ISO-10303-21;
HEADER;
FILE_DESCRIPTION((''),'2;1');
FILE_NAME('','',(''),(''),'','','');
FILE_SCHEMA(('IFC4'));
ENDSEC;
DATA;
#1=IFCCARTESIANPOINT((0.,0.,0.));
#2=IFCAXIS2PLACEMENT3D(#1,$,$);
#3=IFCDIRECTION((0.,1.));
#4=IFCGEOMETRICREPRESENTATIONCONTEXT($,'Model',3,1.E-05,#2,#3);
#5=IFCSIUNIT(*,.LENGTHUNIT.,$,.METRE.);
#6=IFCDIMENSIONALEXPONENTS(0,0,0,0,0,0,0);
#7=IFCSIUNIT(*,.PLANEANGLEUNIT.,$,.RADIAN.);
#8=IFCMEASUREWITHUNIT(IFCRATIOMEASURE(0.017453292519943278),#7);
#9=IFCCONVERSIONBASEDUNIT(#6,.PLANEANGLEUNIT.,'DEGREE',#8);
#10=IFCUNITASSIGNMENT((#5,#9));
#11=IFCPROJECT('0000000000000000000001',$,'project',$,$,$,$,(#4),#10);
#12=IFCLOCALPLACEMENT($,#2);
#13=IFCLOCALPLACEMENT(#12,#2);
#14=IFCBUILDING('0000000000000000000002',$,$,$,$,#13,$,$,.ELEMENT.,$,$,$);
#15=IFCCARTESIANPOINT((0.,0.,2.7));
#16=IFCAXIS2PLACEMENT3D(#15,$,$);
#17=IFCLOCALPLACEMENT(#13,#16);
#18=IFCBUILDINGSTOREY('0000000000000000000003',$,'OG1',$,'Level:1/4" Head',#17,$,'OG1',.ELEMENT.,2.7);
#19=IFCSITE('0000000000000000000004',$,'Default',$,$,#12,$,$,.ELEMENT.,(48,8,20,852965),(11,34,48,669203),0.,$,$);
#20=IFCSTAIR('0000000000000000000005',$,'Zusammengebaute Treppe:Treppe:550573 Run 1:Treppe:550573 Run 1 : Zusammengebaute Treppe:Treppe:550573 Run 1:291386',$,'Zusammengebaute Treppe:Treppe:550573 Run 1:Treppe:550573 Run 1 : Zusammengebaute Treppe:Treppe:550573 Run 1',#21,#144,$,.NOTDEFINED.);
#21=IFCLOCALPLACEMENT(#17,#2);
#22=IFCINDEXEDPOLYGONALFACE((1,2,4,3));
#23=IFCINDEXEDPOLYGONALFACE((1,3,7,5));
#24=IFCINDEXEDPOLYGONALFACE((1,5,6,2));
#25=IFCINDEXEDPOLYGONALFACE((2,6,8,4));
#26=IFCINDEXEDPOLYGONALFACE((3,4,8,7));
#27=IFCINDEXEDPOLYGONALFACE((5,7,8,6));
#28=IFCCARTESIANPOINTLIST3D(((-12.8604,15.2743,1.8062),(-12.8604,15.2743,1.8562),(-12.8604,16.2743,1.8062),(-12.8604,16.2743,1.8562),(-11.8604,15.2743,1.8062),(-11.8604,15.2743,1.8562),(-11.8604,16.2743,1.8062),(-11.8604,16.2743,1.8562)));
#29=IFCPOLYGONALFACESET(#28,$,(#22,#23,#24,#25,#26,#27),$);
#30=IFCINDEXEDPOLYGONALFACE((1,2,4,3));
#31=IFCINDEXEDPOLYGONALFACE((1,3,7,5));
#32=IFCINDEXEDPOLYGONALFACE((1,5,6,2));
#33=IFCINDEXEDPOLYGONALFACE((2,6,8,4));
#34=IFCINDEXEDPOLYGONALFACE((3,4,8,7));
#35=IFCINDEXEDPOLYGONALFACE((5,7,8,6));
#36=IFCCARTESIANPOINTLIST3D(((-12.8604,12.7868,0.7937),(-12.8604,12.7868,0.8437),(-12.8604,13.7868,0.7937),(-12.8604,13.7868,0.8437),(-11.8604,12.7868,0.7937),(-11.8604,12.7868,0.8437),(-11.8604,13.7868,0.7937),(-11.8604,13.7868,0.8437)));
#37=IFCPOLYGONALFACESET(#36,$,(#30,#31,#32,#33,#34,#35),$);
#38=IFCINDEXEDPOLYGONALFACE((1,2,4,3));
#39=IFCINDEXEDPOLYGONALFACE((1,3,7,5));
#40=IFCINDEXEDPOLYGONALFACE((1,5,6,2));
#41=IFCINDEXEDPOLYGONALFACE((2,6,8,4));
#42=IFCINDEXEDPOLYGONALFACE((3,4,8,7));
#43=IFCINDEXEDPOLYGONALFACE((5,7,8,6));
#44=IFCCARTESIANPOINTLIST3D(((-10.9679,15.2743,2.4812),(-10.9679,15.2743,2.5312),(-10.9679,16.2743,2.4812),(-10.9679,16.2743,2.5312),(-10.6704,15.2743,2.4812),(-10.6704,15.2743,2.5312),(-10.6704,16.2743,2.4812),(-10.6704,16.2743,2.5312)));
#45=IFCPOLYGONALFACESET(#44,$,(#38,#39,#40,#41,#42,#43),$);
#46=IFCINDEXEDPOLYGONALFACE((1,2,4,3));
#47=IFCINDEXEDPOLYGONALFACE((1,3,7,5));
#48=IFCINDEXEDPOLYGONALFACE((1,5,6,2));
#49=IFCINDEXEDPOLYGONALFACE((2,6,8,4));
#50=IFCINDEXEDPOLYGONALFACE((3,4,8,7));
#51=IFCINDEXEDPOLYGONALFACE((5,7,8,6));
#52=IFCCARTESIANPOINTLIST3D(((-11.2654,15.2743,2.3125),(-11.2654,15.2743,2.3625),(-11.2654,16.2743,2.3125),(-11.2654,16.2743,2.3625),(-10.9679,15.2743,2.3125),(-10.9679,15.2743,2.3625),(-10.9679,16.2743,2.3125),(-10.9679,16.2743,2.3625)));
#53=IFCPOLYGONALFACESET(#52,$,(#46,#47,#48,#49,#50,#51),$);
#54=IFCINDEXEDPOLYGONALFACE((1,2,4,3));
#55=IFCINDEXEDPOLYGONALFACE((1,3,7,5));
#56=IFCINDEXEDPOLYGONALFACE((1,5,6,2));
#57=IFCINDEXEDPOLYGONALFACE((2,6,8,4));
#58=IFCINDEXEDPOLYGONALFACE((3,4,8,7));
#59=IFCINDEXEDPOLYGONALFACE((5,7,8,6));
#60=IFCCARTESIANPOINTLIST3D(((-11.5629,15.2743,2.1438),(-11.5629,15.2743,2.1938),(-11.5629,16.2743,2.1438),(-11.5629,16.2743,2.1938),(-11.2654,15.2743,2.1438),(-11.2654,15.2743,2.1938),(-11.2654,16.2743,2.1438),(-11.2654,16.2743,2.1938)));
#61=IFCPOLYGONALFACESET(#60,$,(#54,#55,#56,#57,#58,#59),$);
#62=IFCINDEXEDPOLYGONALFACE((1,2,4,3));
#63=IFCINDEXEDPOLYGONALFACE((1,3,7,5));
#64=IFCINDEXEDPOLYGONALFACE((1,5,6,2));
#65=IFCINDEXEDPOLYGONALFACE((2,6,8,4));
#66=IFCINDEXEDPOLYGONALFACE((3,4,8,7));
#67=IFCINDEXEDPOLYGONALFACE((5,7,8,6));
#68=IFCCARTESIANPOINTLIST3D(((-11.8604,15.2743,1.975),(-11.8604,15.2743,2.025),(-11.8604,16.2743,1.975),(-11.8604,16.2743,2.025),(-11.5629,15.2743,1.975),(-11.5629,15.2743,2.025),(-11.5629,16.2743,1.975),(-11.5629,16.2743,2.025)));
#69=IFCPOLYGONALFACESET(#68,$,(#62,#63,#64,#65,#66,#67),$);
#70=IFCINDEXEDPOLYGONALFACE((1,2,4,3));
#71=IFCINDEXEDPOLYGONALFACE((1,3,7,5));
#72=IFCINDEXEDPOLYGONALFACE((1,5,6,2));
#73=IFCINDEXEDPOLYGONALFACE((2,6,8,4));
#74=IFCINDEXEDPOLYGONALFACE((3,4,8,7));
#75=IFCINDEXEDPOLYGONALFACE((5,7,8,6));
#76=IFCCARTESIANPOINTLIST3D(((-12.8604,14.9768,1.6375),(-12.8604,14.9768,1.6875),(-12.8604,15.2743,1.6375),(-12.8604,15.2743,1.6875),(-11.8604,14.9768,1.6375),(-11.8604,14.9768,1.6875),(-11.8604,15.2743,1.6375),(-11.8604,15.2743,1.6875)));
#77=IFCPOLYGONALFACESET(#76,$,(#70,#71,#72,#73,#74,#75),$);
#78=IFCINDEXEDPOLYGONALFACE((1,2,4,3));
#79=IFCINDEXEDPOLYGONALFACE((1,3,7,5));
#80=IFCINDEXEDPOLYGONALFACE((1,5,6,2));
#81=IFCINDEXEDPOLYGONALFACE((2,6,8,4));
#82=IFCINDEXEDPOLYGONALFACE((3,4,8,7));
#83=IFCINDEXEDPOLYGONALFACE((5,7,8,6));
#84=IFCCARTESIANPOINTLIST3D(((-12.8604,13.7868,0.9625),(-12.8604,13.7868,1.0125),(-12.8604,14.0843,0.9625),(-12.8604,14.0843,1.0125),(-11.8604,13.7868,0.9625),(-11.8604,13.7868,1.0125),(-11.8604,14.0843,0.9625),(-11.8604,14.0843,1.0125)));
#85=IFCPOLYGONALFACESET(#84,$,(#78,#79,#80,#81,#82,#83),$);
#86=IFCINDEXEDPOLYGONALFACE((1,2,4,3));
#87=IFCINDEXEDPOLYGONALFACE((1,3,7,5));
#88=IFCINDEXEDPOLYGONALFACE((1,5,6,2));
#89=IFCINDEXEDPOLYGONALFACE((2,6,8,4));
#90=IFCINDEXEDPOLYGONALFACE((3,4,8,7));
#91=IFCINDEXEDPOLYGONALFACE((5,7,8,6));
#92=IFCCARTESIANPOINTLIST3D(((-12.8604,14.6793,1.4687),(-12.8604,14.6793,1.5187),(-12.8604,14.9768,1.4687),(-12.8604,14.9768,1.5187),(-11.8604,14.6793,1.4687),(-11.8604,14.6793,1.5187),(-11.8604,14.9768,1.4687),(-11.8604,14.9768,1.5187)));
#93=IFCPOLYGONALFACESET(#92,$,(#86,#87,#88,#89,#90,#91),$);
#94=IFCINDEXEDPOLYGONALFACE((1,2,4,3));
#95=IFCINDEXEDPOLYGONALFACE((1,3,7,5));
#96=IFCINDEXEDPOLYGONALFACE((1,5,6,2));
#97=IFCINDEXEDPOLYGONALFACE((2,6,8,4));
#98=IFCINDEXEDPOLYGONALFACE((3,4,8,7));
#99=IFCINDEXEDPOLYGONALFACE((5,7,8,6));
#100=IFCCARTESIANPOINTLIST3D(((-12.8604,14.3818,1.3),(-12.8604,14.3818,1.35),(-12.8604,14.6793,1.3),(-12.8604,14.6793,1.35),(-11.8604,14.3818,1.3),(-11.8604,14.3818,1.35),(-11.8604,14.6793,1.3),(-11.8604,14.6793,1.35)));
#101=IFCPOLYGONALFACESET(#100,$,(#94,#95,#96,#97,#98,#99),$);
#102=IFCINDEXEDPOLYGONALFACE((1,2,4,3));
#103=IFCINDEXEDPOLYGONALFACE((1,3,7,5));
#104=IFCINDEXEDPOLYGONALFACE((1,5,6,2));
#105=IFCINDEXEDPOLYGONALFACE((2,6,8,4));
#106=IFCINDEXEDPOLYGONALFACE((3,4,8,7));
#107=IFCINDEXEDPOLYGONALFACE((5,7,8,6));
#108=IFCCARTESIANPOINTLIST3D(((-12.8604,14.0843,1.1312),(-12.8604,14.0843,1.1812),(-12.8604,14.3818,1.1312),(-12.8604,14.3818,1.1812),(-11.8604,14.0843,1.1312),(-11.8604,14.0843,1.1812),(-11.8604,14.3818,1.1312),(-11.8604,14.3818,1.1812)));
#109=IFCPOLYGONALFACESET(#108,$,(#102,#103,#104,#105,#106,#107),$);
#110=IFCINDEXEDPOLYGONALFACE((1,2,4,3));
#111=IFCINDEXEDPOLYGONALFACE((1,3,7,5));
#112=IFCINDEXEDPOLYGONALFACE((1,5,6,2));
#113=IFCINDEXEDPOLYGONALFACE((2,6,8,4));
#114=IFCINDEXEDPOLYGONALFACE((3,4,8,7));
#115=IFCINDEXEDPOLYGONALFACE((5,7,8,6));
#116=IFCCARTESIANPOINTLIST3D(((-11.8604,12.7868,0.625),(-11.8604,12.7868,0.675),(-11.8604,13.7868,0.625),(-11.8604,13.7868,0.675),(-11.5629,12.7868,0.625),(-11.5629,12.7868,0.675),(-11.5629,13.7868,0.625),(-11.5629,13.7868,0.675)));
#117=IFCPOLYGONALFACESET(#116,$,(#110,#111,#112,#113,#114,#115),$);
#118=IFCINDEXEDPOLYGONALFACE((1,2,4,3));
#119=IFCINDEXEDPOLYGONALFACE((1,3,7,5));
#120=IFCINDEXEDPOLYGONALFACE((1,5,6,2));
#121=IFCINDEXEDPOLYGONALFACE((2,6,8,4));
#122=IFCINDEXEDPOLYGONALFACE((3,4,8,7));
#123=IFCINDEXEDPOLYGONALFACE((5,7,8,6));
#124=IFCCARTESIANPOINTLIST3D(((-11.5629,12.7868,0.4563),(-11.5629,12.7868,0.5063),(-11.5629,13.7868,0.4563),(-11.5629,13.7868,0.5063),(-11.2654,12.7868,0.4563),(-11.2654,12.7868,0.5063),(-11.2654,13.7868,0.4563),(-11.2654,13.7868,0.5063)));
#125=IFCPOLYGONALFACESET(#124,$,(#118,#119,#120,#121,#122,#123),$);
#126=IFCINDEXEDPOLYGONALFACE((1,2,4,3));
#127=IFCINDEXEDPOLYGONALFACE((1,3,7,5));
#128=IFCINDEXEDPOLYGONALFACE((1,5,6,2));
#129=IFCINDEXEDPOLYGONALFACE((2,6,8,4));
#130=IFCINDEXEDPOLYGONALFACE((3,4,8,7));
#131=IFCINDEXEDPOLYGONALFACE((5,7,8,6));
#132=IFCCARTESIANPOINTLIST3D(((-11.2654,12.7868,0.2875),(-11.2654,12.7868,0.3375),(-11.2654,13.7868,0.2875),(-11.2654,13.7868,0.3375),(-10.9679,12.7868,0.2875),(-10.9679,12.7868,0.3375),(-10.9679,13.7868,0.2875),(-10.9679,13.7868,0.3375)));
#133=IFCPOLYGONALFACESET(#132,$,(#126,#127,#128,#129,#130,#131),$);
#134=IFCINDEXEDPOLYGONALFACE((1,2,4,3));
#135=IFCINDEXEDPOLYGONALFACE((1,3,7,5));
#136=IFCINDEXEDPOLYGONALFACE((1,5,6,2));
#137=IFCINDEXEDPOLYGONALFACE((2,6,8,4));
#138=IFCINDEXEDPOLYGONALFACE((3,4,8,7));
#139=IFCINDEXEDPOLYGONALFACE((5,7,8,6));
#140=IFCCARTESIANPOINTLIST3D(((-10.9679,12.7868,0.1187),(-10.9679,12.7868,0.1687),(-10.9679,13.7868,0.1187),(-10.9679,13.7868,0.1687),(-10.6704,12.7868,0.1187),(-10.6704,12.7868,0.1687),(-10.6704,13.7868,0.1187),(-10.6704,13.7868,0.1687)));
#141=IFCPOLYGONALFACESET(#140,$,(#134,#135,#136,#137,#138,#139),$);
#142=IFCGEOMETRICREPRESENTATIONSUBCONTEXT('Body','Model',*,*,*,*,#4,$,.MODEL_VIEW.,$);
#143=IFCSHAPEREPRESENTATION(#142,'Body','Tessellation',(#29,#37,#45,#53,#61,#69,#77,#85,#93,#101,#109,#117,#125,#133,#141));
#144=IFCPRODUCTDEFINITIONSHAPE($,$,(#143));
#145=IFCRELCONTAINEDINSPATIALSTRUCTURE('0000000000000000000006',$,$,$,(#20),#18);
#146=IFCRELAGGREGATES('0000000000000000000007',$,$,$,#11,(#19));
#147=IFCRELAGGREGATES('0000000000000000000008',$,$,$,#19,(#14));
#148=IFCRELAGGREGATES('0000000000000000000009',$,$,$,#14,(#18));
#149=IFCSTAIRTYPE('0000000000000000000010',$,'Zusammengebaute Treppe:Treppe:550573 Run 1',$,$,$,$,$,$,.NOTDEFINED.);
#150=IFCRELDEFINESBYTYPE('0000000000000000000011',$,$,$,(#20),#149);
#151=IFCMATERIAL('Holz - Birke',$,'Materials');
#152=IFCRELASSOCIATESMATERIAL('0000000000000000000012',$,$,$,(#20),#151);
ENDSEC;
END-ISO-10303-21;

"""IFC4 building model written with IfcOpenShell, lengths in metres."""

from ifc_helpers import new_model, entity, si_unit, converted_unit, direction, frame, origin, place, context, subcontext, project, spatial, indexed_curve, outline, extrude, material, type_object, element, save


model = new_model("IFC4")

# Units and contexts
model_context = context("Model", 3, precision=1e-05, world=origin(), true_north=direction((0.0, 1.0)))
body_context = subcontext(model_context, "Body", "Model", "MODEL_VIEW")
ifc_project = project(units=[si_unit("LENGTHUNIT", "METRE"), converted_unit("PLANEANGLEUNIT", "DEGREE", entity("IfcRatioMeasure", 0.017453292519943278), si_unit("PLANEANGLEUNIT", "RADIAN"), dimensions=[0, 0, 0, 0, 0, 0, 0])], contexts=[model_context])

# Site, building, storey
site_placement = place(None, origin())
site = spatial("IfcSite", under=ifc_project, at=site_placement, Name="Default", CompositionType="ELEMENT", RefLatitude=(48, 8, 20, 852965), RefLongitude=(11, 34, 48, 669203), RefElevation=0.0)
building_placement = place(site_placement, origin())
building = spatial("IfcBuilding", under=site, at=building_placement, CompositionType="ELEMENT")
storey_placement = place(building_placement, frame((0.0, 0.0, 2.7)))
storey = spatial("IfcBuildingStorey", under=building, at=storey_placement, Name="OG1", ObjectType="Level:1/4\" Head", LongName="OG1", CompositionType="ELEMENT", Elevation=2.7)

# Stair
ifc_material_1 = material(Name="Holz - Birke", Category="Materials")
stair_type_1 = type_object("IfcStairType", Name="Zusammengebaute Treppe:Treppe:550573 Run 1", PredefinedType="NOTDEFINED")
stair_1_placement = place(storey_placement, origin())
element("IfcStair", 1, at=stair_1_placement, inside=storey, type_object=stair_type_1, material=ifc_material_1, Name="Zusammengebaute Treppe:Treppe:550573 Run 1:Treppe:550573 Run 1 : Zusammengebaute Treppe:Treppe:550573 Run 1:291386", ObjectType="Zusammengebaute Treppe:Treppe:550573 Run 1:Treppe:550573 Run 1 : Zusammengebaute Treppe:Treppe:550573 Run 1", PredefinedType="NOTDEFINED", context=body_context, shape_type="SweptSolid", body=[
    extrude(outline(indexed_curve([(-0.5, -0.5), (0.5, -0.5), (0.5, 0.5), (-0.5, 0.5), (-0.5, -0.5)], self_intersect=False)), frame((-12.3604, 15.7743, 1.8062), z_axis=(0.0, 0.0, 1.0), x_axis=(0.0, 1.0, 0.0)), (0.0, 0.0, 1.0), 0.05),
    extrude(outline(indexed_curve([(-0.5, -0.5), (0.5, -0.5), (0.5, 0.5), (-0.5, 0.5), (-0.5, -0.5)], self_intersect=False)), frame((-12.3604, 13.2868, 0.7937), z_axis=(0.0, 0.0, 1.0), x_axis=(-1.0, 0.0, 0.0)), (0.0, 0.0, 1.0), 0.05),
    extrude(outline(indexed_curve([(-0.5, -0.1487), (0.5, -0.1487), (0.5, 0.1487), (-0.5, 0.1487), (-0.5, -0.1487)], self_intersect=False)), frame((-10.8191, 15.7743, 2.4813), z_axis=(0.0, 0.0, 1.0), x_axis=(0.0, -1.0, 0.0)), (0.0, 0.0, 1.0), 0.05),
    extrude(outline(indexed_curve([(-0.5, -0.1487), (0.5, -0.1487), (0.5, 0.1487), (-0.5, 0.1487), (-0.5, -0.1487)], self_intersect=False)), frame((-11.1166, 15.7743, 2.3125), z_axis=(0.0, 0.0, 1.0), x_axis=(0.0, -1.0, 0.0)), (0.0, 0.0, 1.0), 0.05),
    extrude(outline(indexed_curve([(-0.5, -0.1487), (0.5, -0.1487), (0.5, 0.1487), (-0.5, 0.1487), (-0.5, -0.1487)], self_intersect=False)), frame((-11.4141, 15.7743, 2.1438), z_axis=(0.0, 0.0, 1.0), x_axis=(0.0, -1.0, 0.0)), (0.0, 0.0, 1.0), 0.05),
    extrude(outline(indexed_curve([(-0.5, -0.1488), (0.5, -0.1488), (0.5, 0.1488), (-0.5, 0.1488), (-0.5, -0.1488)], self_intersect=False)), frame((-11.7116, 15.7743, 1.975), z_axis=(0.0, 0.0, 1.0), x_axis=(0.0, -1.0, 0.0)), (0.0, 0.0, 1.0), 0.05),
    extrude(outline(indexed_curve([(-0.5, -0.1487), (0.5, -0.1487), (0.5, 0.1488), (-0.5, 0.1488), (-0.5, -0.1487)], self_intersect=False)), frame((-12.3604, 15.1256, 1.6375)), (0.0, 0.0, 1.0), 0.05),
    extrude(outline(indexed_curve([(-0.5, -0.1487), (0.5, -0.1487), (0.5, 0.1488), (-0.5, 0.1488), (-0.5, -0.1487)], self_intersect=False)), frame((-12.3604, 13.9356, 0.9625)), (0.0, 0.0, 1.0), 0.05),
    extrude(outline(indexed_curve([(-0.5, -0.1487), (0.5, -0.1487), (0.5, 0.1488), (-0.5, 0.1488), (-0.5, -0.1487)], self_intersect=False)), frame((-12.3604, 14.8281, 1.4687)), (0.0, 0.0, 1.0), 0.05),
    extrude(outline(indexed_curve([(-0.5, -0.1487), (0.5, -0.1487), (0.5, 0.1488), (-0.5, 0.1488), (-0.5, -0.1487)], self_intersect=False)), frame((-12.3604, 14.5306, 1.3)), (0.0, 0.0, 1.0), 0.05),
    extrude(outline(indexed_curve([(-0.5, -0.1488), (0.5, -0.1488), (0.5, 0.1487), (-0.5, 0.1487), (-0.5, -0.1488)], self_intersect=False)), frame((-12.3604, 14.2331, 1.1313)), (0.0, 0.0, 1.0), 0.05),
    extrude(outline(indexed_curve([(-0.5, -0.1487), (0.5, -0.1487), (0.5, 0.1487), (-0.5, 0.1487), (-0.5, -0.1487)], self_intersect=False)), frame((-11.7116, 13.2868, 0.625), z_axis=(0.0, 0.0, 1.0), x_axis=(0.0, 1.0, 0.0)), (0.0, 0.0, 1.0), 0.05),
    extrude(outline(indexed_curve([(-0.5, -0.1487), (0.5, -0.1487), (0.5, 0.1487), (-0.5, 0.1487), (-0.5, -0.1487)], self_intersect=False)), frame((-11.4141, 13.2868, 0.4563), z_axis=(0.0, 0.0, 1.0), x_axis=(0.0, 1.0, 0.0)), (0.0, 0.0, 1.0), 0.05),
    extrude(outline(indexed_curve([(-0.5, -0.1487), (0.5, -0.1487), (0.5, 0.1487), (-0.5, 0.1487), (-0.5, -0.1487)], self_intersect=False)), frame((-11.1166, 13.2868, 0.2875), z_axis=(0.0, 0.0, 1.0), x_axis=(0.0, 1.0, 0.0)), (0.0, 0.0, 1.0), 0.05),
    extrude(outline(indexed_curve([(-0.5, -0.1488), (0.5, -0.1488), (0.5, 0.1488), (-0.5, 0.1488), (-0.5, -0.1488)], self_intersect=False)), frame((-10.8191, 13.2868, 0.1187), z_axis=(0.0, 0.0, 1.0), x_axis=(0.0, 1.0, 0.0)), (0.0, 0.0, 1.0), 0.05),
])

save(model, "model.ifc")
